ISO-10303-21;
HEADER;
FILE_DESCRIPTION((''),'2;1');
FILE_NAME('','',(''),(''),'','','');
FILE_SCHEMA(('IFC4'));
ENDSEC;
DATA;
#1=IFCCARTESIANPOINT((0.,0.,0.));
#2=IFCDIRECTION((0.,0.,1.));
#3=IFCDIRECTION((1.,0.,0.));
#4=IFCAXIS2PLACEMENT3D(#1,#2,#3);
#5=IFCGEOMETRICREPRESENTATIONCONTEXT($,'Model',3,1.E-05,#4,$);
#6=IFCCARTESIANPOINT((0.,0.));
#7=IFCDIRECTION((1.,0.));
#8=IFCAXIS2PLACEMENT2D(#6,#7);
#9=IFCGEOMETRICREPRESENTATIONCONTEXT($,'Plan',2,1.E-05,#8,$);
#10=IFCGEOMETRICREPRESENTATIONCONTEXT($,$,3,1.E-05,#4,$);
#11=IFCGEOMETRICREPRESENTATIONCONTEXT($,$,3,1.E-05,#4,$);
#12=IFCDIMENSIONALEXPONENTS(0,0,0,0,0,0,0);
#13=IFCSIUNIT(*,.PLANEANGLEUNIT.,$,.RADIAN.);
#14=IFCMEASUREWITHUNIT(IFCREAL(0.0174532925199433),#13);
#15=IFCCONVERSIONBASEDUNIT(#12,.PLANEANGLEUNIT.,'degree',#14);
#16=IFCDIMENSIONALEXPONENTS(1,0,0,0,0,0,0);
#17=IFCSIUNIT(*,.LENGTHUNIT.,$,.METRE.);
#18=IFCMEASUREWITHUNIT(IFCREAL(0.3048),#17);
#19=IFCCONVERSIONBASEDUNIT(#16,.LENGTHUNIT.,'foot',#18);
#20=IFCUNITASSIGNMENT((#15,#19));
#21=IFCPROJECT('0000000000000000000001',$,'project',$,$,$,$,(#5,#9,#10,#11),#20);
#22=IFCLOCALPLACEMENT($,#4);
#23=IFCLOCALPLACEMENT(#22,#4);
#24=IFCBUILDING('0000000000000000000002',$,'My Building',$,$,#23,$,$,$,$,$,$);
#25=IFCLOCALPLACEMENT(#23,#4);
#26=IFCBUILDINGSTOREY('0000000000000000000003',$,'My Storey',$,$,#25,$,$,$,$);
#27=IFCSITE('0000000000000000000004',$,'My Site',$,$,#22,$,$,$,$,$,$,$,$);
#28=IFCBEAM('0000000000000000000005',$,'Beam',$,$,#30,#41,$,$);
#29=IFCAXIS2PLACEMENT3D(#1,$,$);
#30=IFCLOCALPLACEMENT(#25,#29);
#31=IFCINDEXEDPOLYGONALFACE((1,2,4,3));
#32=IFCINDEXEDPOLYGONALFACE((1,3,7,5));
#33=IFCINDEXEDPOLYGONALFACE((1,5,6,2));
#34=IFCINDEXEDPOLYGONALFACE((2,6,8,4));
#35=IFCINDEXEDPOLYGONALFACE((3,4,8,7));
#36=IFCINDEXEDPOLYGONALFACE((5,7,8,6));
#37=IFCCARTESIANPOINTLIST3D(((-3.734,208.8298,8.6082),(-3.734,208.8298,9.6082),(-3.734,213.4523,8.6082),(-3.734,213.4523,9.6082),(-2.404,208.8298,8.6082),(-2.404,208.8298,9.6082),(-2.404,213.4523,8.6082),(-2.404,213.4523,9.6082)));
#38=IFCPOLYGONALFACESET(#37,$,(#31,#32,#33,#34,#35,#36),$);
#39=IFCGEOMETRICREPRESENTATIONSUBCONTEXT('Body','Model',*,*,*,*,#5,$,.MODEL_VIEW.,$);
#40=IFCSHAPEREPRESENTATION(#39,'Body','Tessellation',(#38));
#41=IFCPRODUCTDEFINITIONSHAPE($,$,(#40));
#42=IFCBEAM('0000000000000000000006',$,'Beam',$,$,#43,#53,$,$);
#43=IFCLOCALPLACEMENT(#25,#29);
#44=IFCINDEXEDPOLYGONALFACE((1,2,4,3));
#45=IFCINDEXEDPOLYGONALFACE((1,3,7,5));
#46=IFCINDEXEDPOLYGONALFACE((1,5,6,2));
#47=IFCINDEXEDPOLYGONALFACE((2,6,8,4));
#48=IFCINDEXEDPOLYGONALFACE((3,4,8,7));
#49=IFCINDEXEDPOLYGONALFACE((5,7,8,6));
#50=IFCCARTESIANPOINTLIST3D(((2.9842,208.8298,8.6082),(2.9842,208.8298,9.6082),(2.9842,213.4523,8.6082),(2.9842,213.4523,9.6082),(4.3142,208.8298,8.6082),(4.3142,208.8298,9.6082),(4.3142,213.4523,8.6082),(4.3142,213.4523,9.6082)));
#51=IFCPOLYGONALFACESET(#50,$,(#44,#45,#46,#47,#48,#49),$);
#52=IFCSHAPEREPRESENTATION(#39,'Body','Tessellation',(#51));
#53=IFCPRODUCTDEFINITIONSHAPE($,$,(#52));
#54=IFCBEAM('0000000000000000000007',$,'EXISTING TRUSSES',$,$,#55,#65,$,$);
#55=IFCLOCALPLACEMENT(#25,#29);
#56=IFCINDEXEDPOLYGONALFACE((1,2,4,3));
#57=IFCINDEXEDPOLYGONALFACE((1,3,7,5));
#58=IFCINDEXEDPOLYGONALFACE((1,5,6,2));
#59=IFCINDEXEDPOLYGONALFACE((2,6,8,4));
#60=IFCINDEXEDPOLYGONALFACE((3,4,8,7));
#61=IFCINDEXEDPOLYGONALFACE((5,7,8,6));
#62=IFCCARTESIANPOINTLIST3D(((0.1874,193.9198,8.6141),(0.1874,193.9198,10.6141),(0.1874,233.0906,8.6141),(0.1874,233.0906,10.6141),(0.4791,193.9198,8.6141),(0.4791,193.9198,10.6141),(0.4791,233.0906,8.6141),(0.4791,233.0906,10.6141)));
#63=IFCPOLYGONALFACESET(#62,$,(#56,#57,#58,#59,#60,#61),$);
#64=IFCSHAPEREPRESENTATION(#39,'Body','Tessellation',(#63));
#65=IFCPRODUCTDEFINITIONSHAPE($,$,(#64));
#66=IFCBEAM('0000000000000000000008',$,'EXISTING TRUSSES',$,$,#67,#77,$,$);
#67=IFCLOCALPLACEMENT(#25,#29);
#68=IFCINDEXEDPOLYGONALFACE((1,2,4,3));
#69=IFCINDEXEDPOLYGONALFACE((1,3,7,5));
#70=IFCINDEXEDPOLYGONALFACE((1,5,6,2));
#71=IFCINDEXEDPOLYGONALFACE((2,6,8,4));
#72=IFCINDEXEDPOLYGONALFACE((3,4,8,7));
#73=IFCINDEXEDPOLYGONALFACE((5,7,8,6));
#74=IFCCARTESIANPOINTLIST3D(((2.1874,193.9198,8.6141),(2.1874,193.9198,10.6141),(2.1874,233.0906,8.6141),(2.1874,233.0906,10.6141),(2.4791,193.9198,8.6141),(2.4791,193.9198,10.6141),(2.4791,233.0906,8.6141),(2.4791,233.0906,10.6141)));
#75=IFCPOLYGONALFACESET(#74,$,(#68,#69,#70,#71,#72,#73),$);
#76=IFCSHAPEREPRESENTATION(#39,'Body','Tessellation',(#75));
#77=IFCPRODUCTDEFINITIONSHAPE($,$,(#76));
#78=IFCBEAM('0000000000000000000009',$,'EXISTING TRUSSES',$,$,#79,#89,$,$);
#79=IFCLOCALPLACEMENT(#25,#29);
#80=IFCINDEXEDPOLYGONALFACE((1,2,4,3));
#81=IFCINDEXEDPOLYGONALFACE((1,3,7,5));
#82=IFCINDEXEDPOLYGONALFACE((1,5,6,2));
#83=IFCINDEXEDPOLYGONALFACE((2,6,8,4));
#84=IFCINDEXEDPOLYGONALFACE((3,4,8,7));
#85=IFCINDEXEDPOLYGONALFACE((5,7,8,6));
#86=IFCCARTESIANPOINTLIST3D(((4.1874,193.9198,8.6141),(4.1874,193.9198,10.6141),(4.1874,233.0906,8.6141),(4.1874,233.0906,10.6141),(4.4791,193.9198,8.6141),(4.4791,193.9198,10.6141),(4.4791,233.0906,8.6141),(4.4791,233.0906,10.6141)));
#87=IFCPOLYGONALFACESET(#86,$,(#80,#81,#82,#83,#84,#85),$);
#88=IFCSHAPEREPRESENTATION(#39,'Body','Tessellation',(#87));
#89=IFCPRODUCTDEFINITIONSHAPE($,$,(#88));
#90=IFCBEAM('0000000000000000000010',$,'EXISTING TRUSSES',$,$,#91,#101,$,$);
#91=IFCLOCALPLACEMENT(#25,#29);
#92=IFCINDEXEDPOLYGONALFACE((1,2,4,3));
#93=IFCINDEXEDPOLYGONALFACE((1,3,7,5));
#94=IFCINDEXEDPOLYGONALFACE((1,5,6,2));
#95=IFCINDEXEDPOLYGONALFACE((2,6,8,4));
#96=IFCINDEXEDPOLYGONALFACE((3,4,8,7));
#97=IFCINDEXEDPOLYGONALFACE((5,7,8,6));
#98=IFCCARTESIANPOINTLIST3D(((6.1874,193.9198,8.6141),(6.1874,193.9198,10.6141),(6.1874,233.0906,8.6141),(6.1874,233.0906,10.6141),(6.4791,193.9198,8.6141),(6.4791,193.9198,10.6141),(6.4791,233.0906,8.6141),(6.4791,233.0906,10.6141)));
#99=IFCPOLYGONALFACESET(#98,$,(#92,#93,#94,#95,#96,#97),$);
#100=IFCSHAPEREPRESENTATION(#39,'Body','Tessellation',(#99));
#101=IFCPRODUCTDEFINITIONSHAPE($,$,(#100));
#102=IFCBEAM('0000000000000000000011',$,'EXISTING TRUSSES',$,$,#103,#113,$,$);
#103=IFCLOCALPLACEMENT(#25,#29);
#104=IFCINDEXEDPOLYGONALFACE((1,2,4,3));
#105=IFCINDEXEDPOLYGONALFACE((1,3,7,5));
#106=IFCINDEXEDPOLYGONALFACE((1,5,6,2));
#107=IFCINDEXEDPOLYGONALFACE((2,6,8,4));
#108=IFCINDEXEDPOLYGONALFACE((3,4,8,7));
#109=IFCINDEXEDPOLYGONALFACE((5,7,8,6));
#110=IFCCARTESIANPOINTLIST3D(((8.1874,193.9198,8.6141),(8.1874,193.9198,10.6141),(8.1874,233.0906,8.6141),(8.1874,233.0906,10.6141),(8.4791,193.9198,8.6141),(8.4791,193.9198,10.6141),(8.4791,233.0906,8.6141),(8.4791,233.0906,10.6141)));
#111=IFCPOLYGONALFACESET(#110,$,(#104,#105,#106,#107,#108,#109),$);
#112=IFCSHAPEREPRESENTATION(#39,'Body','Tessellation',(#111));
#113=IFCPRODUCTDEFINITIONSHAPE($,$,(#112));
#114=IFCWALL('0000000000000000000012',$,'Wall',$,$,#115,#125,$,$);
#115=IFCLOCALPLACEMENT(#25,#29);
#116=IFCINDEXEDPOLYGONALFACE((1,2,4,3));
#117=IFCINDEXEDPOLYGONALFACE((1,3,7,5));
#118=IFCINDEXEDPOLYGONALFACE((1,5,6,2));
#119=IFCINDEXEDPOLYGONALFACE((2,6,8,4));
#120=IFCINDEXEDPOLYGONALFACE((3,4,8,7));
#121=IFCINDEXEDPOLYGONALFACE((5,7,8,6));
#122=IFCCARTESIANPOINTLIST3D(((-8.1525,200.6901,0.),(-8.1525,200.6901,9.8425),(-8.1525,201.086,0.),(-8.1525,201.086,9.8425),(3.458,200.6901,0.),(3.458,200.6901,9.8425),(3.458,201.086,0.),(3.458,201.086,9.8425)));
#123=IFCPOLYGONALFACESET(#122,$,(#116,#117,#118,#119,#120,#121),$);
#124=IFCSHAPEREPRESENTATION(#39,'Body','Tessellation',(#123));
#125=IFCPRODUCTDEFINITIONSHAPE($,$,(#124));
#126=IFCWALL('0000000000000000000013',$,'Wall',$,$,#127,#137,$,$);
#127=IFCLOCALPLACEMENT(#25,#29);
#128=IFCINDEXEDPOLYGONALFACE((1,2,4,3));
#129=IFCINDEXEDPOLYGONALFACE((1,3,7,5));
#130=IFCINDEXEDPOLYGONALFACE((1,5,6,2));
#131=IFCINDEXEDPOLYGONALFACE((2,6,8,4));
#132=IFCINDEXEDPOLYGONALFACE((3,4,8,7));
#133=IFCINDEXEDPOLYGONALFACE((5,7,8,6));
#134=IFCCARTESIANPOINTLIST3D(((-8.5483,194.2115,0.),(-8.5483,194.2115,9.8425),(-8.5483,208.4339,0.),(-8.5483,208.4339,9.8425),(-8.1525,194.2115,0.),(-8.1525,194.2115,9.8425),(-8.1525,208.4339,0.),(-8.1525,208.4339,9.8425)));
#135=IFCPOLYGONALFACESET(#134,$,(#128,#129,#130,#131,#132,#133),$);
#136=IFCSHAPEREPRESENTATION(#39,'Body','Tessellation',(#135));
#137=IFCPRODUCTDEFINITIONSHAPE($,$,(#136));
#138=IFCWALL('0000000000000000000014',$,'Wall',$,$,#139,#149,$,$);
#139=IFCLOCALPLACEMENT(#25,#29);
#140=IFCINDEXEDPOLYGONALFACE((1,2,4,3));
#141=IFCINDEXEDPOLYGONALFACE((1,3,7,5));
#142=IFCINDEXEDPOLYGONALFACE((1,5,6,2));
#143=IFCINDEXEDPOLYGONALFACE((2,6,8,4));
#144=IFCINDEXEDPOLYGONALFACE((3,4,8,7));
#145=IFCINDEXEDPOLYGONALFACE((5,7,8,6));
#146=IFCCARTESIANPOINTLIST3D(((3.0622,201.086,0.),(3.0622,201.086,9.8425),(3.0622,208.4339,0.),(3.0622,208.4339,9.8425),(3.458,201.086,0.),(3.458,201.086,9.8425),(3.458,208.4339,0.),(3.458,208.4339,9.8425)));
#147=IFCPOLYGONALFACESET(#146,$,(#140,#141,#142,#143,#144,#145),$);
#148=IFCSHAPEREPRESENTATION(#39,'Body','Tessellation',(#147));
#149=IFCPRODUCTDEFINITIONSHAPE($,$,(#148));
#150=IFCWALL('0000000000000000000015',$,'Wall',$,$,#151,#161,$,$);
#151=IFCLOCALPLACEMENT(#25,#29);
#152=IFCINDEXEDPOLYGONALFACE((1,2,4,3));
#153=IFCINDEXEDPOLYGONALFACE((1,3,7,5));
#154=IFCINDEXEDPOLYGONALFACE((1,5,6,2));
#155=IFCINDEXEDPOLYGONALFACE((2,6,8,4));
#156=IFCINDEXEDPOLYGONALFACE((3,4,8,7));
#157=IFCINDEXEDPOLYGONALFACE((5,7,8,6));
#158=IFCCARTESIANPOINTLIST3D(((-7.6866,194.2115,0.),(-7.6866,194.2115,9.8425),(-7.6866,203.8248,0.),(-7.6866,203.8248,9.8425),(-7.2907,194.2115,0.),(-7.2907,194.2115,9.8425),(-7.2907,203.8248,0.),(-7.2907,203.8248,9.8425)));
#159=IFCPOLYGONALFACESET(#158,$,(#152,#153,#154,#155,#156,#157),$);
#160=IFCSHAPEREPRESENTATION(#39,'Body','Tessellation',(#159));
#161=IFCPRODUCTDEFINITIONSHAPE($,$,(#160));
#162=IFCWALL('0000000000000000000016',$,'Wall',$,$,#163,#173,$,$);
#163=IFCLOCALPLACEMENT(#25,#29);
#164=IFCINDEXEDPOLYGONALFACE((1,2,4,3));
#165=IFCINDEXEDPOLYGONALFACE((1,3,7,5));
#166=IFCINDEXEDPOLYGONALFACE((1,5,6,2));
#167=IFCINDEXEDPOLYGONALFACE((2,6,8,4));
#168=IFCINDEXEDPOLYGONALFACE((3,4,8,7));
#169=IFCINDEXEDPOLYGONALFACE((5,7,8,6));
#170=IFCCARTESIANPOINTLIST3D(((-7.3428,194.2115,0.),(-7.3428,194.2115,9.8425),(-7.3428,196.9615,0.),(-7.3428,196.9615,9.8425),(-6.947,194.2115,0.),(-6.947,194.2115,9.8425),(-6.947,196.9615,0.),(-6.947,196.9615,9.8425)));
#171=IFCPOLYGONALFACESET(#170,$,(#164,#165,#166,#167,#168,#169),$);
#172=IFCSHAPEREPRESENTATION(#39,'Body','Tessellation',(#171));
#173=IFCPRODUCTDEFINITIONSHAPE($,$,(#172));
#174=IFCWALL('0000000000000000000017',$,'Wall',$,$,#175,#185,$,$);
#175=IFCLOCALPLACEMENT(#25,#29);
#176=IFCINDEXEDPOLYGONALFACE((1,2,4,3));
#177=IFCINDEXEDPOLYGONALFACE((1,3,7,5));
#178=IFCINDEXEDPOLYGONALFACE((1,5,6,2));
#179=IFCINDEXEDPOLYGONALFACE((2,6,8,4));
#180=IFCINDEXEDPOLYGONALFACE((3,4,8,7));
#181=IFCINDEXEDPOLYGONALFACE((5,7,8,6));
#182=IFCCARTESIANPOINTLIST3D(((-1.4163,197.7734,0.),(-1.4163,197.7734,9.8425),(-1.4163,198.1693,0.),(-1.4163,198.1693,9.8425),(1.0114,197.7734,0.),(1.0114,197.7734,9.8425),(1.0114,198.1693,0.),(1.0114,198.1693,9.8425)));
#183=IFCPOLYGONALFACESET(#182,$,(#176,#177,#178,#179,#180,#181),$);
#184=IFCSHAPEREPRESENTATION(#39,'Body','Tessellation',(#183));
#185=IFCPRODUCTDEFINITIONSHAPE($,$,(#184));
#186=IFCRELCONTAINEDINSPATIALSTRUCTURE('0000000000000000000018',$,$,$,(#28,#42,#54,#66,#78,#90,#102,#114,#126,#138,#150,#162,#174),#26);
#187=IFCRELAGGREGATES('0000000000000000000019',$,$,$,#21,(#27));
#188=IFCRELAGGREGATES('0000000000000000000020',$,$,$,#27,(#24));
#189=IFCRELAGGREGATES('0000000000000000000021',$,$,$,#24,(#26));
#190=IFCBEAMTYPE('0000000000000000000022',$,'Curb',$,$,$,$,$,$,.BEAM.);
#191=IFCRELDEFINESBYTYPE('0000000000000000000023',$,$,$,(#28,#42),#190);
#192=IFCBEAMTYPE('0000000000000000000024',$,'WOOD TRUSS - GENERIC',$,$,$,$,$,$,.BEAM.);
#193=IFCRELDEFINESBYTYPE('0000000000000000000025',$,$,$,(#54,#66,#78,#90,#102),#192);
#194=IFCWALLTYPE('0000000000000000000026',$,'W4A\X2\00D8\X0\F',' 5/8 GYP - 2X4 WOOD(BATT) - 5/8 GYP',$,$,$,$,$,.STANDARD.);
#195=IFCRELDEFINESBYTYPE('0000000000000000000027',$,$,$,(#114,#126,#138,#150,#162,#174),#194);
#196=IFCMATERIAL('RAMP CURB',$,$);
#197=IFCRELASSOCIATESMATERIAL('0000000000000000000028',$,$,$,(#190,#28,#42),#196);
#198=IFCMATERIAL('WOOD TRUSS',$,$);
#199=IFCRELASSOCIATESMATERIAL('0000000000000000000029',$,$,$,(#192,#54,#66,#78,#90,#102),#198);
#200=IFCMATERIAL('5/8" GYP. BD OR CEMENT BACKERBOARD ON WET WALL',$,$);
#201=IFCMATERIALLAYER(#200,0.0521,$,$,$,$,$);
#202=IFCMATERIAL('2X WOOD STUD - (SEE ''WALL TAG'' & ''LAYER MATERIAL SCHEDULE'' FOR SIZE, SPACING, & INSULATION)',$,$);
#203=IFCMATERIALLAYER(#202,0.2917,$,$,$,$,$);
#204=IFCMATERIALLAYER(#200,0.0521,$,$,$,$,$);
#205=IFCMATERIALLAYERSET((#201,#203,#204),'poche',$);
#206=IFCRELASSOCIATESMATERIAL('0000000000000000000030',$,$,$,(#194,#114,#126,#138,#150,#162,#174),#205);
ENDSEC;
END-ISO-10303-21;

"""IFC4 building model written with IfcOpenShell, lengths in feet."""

from ifc_helpers import new_model, entity, si_unit, converted_unit, frame, origin_with_axes, origin_2d_with_axis, place, context, subcontext, project, spatial, indexed_curve, rectangle, outline, extrude, material, layer, layer_set, layer_usage, material_profile, profile_set, profile_usage, type_object, element, save


model = new_model("IFC4")

# Units and contexts
model_context = context("Model", 3, precision=1e-05, world=origin_with_axes())
plan_context = context("Plan", 2, precision=1e-05, world=origin_2d_with_axis())
context_of_model_1 = context(None, 3, precision=1e-05, world=origin_with_axes())
context_of_model_2 = context(None, 3, precision=1e-05, world=origin_with_axes())
body_context_1 = subcontext(model_context, "Body", "Model", "MODEL_VIEW")
ifc_project = project(units=[converted_unit("PLANEANGLEUNIT", "degree", entity("IfcReal", 0.0174532925199433), si_unit("PLANEANGLEUNIT", "RADIAN"), dimensions=[0, 0, 0, 0, 0, 0, 0]), converted_unit("LENGTHUNIT", "foot", entity("IfcReal", 0.3048), si_unit("LENGTHUNIT", "METRE"), dimensions=[1, 0, 0, 0, 0, 0, 0])], contexts=[model_context, plan_context, context_of_model_1, context_of_model_2])

# Site, building, storey
site_placement = place(None, origin_with_axes())
site = spatial("IfcSite", under=ifc_project, at=site_placement, Name="My Site")
building_placement = place(site_placement, origin_with_axes())
building = spatial("IfcBuilding", under=site, at=building_placement, Name="My Building")
storey_placement = place(building_placement, origin_with_axes())
storey = spatial("IfcBuildingStorey", under=building, at=storey_placement, Name="My Storey")

# Beams
ifc_material_1 = material(Name="RAMP CURB")
ifc_material_profile_1 = material_profile(ifc_material_1, rectangle(XDim=1.33, YDim=1.0))
ifc_profile_set_1 = profile_set([ifc_material_profile_1])
ifc_profile_usage_1 = profile_usage(ifc_profile_set_1, cardinal=5)
beam_type_1 = type_object("IfcBeamType", Name="Curb", PredefinedType="BEAM", material=ifc_profile_set_1)
beam_1_placement = place(storey_placement, frame((-3.069, 208.8298, 9.1082), z_axis=(0.0, 1.0, 0.0), x_axis=(-1.0, 0.0, 0.0)))
element("IfcBeam", 1, at=beam_1_placement, inside=storey, type_object=beam_type_1, material=ifc_profile_usage_1, Name="Beam", context=body_context_1, shape_type="SweptSolid", body=[
    extrude(rectangle(XDim=1.33, YDim=1.0), origin_with_axes(), (0.0, 0.0, 1.0), 4.6225),
])
ifc_profile_usage_2 = profile_usage(ifc_profile_set_1, cardinal=5)
beam_2_placement = place(storey_placement, frame((3.6492, 208.8298, 9.1082), z_axis=(0.0, 1.0, 0.0), x_axis=(-1.0, 0.0, 0.0)))
element("IfcBeam", 2, at=beam_2_placement, inside=storey, type_object=beam_type_1, material=ifc_profile_usage_2, Name="Beam", context=body_context_1, shape_type="SweptSolid", body=[
    extrude(rectangle(XDim=1.33, YDim=1.0), origin_with_axes(), (0.0, 0.0, 1.0), 4.6225),
])
ifc_material_2 = material(Name="WOOD TRUSS")
ifc_material_profile_2 = material_profile(ifc_material_2, rectangle(XDim=0.2917, YDim=2.0))
ifc_profile_set_2 = profile_set([ifc_material_profile_2])
ifc_profile_usage_3 = profile_usage(ifc_profile_set_2, cardinal=5)
beam_type_2 = type_object("IfcBeamType", Name="WOOD TRUSS - GENERIC", PredefinedType="BEAM", material=ifc_profile_set_2)
beam_3_placement = place(storey_placement, frame((0.3333, 193.9198, 9.6141), z_axis=(0.0, 1.0, 0.0), x_axis=(-1.0, 0.0, 0.0)))
element("IfcBeam", 3, at=beam_3_placement, inside=storey, type_object=beam_type_2, material=ifc_profile_usage_3, Name="EXISTING TRUSSES", context=body_context_1, shape_type="SweptSolid", body=[
    extrude(rectangle(XDim=0.2917, YDim=2.0), origin_with_axes(), (0.0, 0.0, 1.0), 39.1707),
])
ifc_profile_usage_4 = profile_usage(ifc_profile_set_2, cardinal=5)
beam_4_placement = place(storey_placement, frame((2.3333, 193.9198, 9.6141), z_axis=(0.0, 1.0, 0.0), x_axis=(-1.0, 0.0, 0.0)))
element("IfcBeam", 4, at=beam_4_placement, inside=storey, type_object=beam_type_2, material=ifc_profile_usage_4, Name="EXISTING TRUSSES", context=body_context_1, shape_type="SweptSolid", body=[
    extrude(rectangle(XDim=0.2917, YDim=2.0), origin_with_axes(), (0.0, 0.0, 1.0), 39.1707),
])
ifc_profile_usage_5 = profile_usage(ifc_profile_set_2, cardinal=5)
beam_5_placement = place(storey_placement, frame((4.3333, 193.9198, 9.6141), z_axis=(0.0, 1.0, 0.0), x_axis=(-1.0, 0.0, 0.0)))
element("IfcBeam", 5, at=beam_5_placement, inside=storey, type_object=beam_type_2, material=ifc_profile_usage_5, Name="EXISTING TRUSSES", context=body_context_1, shape_type="SweptSolid", body=[
    extrude(rectangle(XDim=0.2917, YDim=2.0), origin_with_axes(), (0.0, 0.0, 1.0), 39.1707),
])
ifc_profile_usage_6 = profile_usage(ifc_profile_set_2, cardinal=5)
beam_6_placement = place(storey_placement, frame((6.3333, 193.9198, 9.6141), z_axis=(0.0, 1.0, 0.0), x_axis=(-1.0, 0.0, 0.0)))
element("IfcBeam", 6, at=beam_6_placement, inside=storey, type_object=beam_type_2, material=ifc_profile_usage_6, Name="EXISTING TRUSSES", context=body_context_1, shape_type="SweptSolid", body=[
    extrude(rectangle(XDim=0.2917, YDim=2.0), origin_with_axes(), (0.0, 0.0, 1.0), 39.1707),
])
ifc_profile_usage_7 = profile_usage(ifc_profile_set_2, cardinal=5)
beam_7_placement = place(storey_placement, frame((8.3333, 193.9198, 9.6141), z_axis=(0.0, 1.0, 0.0), x_axis=(-1.0, 0.0, 0.0)))
element("IfcBeam", 7, at=beam_7_placement, inside=storey, type_object=beam_type_2, material=ifc_profile_usage_7, Name="EXISTING TRUSSES", context=body_context_1, shape_type="SweptSolid", body=[
    extrude(rectangle(XDim=0.2917, YDim=2.0), origin_with_axes(), (0.0, 0.0, 1.0), 39.1707),
])

# Walls
ifc_material_3 = material(Name="5/8\" GYP. BD OR CEMENT BACKERBOARD ON WET WALL")
ifc_layer_1 = layer(ifc_material_3, 0.0521)
ifc_material_4 = material(Name="2X WOOD STUD - (SEE 'WALL TAG' & 'LAYER MATERIAL SCHEDULE' FOR SIZE, SPACING, & INSULATION)")
ifc_layer_2 = layer(ifc_material_4, 0.2917)
ifc_layer_3 = layer(ifc_material_3, 0.0521)
ifc_layer_set_1 = layer_set([ifc_layer_1, ifc_layer_2, ifc_layer_3], Name="poche")
ifc_layer_usage_1 = layer_usage(ifc_layer_set_1, "AXIS2", "POSITIVE", 0.0)
wall_type_1 = type_object("IfcWallType", Name="W4AØF", Description=" 5/8 GYP - 2X4 WOOD(BATT) - 5/8 GYP", PredefinedType="STANDARD", material=ifc_layer_set_1)
wall_1_placement = place(storey_placement, frame((-8.1525, 200.6901, 0.0), z_axis=(0.0, 0.0, 1.0), x_axis=(1.0, 0.0, 0.0)))
element("IfcWall", 8, at=wall_1_placement, inside=storey, type_object=wall_type_1, material=ifc_layer_usage_1, Name="Wall", context=body_context_1, shape_type="SweptSolid", body=[
    extrude(outline(indexed_curve([(0.0, 0.0), (0.0, 0.3958), (11.6105, 0.3958), (11.6105, 0.0), (0.0, 0.0)], self_intersect=False)), origin_with_axes(), (0.0, 0.0, 1.0), 9.8425),
])
ifc_layer_usage_2 = layer_usage(ifc_layer_set_1, "AXIS2", "POSITIVE", 0.0)
wall_2_placement = place(storey_placement, frame((-8.1525, 194.2115, 0.0), z_axis=(0.0, 0.0, 1.0), x_axis=(0.000001, 1.0, 0.0)))
element("IfcWall", 9, at=wall_2_placement, inside=storey, type_object=wall_type_1, material=ifc_layer_usage_2, Name="Wall", context=body_context_1, shape_type="SweptSolid", body=[
    extrude(outline(indexed_curve([(0.0, 0.0), (0.0, 0.3958), (14.2224, 0.3958), (14.2224, 0.0), (0.0, 0.0)], self_intersect=False)), origin_with_axes(), (0.0, 0.0, 1.0), 9.8425),
])
ifc_layer_usage_3 = layer_usage(ifc_layer_set_1, "AXIS2", "POSITIVE", 0.0)
wall_3_placement = place(storey_placement, frame((3.458, 201.086, 0.0), z_axis=(0.0, 0.0, 1.0), x_axis=(0.000001, 1.0, 0.0)))
element("IfcWall", 10, at=wall_3_placement, inside=storey, type_object=wall_type_1, material=ifc_layer_usage_3, Name="Wall", context=body_context_1, shape_type="SweptSolid", body=[
    extrude(outline(indexed_curve([(0.0, 0.0), (0.0, 0.3958), (7.3479, 0.3958), (7.3479, 0.0), (0.0, 0.0)], self_intersect=False)), origin_with_axes(), (0.0, 0.0, 1.0), 9.8425),
])

# Wall
ifc_layer_usage_4 = layer_usage(ifc_layer_set_1, "AXIS2", "POSITIVE", 0.0)
wall_4_placement = place(storey_placement, frame((-7.2907, 194.2115, 0.0), z_axis=(0.0, 0.0, 1.0), x_axis=(0.0, 1.0, 0.0)))
element("IfcWall", 11, at=wall_4_placement, inside=storey, type_object=wall_type_1, material=ifc_layer_usage_4, Name="Wall", context=body_context_1, shape_type="SweptSolid", body=[
    extrude(outline(indexed_curve([(0.0, 0.0), (0.0, 0.3958), (9.6133, 0.3958), (9.6133, 0.0), (0.0, 0.0)], self_intersect=False)), origin_with_axes(), (0.0, 0.0, 1.0), 9.8425),
])

# Walls
ifc_layer_usage_5 = layer_usage(ifc_layer_set_1, "AXIS2", "POSITIVE", 0.0)
wall_5_placement = place(storey_placement, frame((-6.947, 194.2115, 0.0), z_axis=(0.0, 0.0, 1.0), x_axis=(0.0, 1.0, 0.0)))
element("IfcWall", 12, at=wall_5_placement, inside=storey, type_object=wall_type_1, material=ifc_layer_usage_5, Name="Wall", context=body_context_1, shape_type="SweptSolid", body=[
    extrude(outline(indexed_curve([(0.0, 0.0), (0.0, 0.3958), (2.75, 0.3958), (2.75, 0.0), (0.0, 0.0)], self_intersect=False)), origin_with_axes(), (0.0, 0.0, 1.0), 9.8425),
])
ifc_layer_usage_6 = layer_usage(ifc_layer_set_1, "AXIS2", "POSITIVE", 0.0)
wall_6_placement = place(storey_placement, frame((-1.4163, 197.7734, 0.0), z_axis=(0.0, 0.0, 1.0), x_axis=(1.0, -0.000001, 0.0)))
element("IfcWall", 13, at=wall_6_placement, inside=storey, type_object=wall_type_1, material=ifc_layer_usage_6, Name="Wall", context=body_context_1, shape_type="SweptSolid", body=[
    extrude(outline(indexed_curve([(0.0, 0.0), (0.0, 0.3958), (2.4277, 0.3958), (2.4277, 0.0), (0.0, 0.0)], self_intersect=False)), origin_with_axes(), (0.0, 0.0, 1.0), 9.8425),
])

save(model, "model.ifc")
